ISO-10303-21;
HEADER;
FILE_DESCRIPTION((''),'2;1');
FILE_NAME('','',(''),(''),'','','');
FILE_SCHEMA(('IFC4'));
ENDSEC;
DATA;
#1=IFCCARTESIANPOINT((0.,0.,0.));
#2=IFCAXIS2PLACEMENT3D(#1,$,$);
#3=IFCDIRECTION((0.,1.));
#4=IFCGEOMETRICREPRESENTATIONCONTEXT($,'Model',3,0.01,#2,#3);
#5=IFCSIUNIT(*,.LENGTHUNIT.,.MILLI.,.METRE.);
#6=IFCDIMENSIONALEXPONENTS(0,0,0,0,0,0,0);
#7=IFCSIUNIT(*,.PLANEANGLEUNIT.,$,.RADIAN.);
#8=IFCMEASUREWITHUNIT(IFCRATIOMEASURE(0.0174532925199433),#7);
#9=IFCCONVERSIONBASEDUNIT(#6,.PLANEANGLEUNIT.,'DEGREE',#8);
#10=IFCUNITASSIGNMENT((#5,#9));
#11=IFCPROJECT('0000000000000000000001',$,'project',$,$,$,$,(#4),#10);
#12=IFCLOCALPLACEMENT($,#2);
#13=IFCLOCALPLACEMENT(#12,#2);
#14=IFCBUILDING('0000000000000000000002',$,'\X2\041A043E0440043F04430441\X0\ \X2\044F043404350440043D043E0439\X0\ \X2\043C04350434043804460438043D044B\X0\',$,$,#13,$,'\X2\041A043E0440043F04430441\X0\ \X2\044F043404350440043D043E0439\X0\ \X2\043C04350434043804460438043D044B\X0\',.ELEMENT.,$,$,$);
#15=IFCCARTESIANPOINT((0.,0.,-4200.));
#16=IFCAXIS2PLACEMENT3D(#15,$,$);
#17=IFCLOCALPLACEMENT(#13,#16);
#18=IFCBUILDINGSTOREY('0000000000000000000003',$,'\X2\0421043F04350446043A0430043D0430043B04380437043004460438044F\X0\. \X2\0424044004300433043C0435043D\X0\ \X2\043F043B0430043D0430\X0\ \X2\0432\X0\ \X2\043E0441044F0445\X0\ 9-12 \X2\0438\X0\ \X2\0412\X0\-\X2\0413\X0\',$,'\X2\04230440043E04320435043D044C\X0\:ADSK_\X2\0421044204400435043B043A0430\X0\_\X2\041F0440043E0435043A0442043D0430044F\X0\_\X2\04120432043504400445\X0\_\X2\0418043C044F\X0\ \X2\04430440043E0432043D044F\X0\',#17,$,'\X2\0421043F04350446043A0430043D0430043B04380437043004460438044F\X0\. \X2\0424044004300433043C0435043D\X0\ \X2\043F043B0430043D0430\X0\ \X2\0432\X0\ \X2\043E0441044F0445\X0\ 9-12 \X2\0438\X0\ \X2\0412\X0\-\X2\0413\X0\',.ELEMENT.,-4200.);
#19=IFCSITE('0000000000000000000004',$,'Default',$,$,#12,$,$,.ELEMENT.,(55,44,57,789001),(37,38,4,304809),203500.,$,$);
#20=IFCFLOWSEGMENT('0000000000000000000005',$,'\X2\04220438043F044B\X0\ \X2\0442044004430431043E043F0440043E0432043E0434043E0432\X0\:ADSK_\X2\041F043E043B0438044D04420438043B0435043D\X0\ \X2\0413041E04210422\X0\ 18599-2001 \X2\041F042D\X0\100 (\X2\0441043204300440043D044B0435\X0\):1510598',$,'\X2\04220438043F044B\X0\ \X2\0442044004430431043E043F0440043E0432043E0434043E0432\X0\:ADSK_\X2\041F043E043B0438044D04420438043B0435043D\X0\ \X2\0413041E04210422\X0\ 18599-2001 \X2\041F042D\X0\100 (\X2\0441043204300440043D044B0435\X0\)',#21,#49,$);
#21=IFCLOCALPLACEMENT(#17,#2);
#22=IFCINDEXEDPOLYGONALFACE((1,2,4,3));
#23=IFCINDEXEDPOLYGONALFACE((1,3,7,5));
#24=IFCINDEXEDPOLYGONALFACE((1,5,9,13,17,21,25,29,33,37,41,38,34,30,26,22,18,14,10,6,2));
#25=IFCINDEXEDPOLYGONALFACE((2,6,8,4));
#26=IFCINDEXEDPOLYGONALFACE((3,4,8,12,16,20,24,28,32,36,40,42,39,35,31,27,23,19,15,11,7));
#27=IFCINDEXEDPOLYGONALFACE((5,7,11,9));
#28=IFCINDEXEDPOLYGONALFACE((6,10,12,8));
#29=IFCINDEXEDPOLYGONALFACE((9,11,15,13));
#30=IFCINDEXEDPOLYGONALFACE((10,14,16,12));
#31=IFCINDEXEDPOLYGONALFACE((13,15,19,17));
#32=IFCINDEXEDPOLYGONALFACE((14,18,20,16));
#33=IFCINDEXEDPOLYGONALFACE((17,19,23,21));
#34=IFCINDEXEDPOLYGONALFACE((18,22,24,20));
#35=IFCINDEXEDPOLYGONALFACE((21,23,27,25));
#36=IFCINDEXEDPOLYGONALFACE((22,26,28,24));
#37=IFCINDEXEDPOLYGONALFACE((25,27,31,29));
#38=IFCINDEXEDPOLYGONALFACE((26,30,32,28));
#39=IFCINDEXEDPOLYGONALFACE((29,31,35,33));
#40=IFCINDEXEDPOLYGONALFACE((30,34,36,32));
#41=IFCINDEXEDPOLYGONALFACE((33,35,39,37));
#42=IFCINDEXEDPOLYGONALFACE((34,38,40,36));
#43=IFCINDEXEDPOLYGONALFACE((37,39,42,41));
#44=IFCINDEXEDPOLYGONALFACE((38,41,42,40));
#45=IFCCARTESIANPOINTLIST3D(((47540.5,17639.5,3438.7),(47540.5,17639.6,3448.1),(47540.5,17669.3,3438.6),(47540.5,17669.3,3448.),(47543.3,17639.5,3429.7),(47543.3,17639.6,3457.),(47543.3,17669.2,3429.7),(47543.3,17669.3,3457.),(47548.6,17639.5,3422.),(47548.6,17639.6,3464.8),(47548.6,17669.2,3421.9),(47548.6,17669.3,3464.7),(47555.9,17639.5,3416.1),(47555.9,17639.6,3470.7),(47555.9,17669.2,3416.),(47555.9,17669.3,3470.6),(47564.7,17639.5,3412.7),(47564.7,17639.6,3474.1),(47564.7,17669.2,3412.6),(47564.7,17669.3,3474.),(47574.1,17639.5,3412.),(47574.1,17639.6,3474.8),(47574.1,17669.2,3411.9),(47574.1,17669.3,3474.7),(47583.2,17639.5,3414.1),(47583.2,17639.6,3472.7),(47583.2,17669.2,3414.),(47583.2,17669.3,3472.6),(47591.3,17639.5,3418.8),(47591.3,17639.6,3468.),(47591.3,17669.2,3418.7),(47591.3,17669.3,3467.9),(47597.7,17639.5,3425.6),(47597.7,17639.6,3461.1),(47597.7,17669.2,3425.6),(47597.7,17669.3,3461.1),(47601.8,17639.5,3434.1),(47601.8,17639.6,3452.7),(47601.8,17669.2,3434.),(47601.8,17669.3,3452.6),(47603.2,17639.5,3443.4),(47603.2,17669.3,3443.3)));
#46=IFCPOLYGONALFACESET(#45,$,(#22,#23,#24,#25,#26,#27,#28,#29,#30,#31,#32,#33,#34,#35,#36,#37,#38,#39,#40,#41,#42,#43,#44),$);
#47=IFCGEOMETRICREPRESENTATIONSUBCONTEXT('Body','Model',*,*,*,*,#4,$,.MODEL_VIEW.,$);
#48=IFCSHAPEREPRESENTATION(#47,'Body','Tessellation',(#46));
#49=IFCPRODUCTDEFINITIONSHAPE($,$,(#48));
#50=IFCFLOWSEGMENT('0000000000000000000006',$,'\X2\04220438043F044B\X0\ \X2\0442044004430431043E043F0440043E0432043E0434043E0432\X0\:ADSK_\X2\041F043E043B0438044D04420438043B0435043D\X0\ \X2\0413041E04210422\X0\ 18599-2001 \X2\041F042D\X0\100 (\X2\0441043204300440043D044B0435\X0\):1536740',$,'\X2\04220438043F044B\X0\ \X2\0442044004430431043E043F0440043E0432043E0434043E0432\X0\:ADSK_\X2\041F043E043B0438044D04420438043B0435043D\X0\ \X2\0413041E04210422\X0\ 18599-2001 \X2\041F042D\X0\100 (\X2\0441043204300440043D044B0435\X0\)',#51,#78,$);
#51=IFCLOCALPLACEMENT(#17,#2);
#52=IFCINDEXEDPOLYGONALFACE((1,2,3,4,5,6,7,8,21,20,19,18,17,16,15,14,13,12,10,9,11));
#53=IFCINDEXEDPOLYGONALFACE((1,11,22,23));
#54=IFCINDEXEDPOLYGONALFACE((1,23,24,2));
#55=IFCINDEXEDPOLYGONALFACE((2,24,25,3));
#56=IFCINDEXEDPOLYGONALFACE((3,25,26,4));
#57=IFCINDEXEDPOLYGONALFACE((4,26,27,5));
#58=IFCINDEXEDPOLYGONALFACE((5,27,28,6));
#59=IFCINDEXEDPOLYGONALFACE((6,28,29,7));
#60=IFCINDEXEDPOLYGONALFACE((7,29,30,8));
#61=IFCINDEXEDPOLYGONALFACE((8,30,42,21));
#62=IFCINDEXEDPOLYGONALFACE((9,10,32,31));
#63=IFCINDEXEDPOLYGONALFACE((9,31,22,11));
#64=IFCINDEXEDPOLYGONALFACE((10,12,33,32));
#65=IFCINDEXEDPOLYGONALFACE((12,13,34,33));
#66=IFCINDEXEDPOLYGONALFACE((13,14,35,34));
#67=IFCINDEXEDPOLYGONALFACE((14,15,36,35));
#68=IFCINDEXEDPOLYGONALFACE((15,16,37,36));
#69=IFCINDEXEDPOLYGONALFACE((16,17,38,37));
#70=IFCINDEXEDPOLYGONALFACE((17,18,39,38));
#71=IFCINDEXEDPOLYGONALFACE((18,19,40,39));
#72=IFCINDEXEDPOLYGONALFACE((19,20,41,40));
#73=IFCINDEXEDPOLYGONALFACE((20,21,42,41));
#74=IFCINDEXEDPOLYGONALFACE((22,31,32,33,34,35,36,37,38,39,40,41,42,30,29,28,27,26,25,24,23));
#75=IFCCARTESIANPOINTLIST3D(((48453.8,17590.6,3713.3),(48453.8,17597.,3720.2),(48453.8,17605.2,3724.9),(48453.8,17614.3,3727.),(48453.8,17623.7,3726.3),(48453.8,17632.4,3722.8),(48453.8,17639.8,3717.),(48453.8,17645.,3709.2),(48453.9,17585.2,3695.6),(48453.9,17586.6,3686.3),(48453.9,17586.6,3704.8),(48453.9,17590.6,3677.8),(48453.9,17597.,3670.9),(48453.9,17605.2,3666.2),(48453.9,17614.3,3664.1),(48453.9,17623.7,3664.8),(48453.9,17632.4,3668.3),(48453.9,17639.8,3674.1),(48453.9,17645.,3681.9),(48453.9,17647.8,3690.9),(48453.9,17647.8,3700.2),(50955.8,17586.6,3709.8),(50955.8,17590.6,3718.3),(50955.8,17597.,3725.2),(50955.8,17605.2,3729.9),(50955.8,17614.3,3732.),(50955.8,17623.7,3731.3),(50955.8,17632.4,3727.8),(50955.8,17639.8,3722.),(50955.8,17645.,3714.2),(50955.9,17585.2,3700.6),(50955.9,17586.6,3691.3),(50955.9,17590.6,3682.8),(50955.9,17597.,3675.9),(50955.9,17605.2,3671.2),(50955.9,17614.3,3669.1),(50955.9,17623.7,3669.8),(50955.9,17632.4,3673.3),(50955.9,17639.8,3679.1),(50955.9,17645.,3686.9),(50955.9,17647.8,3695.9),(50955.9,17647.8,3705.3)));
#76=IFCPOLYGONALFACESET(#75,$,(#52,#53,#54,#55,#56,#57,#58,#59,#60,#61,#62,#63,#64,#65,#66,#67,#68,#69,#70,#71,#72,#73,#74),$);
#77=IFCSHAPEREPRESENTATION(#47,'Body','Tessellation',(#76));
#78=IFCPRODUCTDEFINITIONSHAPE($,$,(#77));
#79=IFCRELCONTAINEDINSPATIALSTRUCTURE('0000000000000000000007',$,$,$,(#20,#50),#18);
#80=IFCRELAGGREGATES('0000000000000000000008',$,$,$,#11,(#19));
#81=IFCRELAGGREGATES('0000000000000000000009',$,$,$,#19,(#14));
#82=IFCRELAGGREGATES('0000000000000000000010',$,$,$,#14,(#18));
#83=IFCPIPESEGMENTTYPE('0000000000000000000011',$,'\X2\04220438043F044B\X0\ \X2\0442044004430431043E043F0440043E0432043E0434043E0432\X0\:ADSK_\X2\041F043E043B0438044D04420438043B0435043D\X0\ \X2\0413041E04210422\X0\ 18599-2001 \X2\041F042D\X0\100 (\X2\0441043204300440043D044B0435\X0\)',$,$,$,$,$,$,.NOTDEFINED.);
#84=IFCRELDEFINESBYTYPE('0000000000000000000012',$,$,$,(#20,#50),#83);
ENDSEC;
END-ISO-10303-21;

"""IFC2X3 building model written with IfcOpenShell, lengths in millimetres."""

from ifc_helpers import new_model, entity, si_unit, converted_unit, direction, frame, frame_2d, origin, origin_2d_with_axis, place, context, subcontext, project, spatial, circle, extrude, type_object, element, save


model = new_model("IFC2X3")

# Units and contexts
model_context = context("Model", 3, precision=0.01, world=origin(), true_north=direction((0.0, 1.0)))
body_context = subcontext(model_context, "Body", "Model", "MODEL_VIEW")
ifc_project = project(units=[si_unit("LENGTHUNIT", "METRE", prefix="MILLI"), converted_unit("PLANEANGLEUNIT", "DEGREE", entity("IfcRatioMeasure", 0.0174532925199433), si_unit("PLANEANGLEUNIT", "RADIAN"), dimensions=[0, 0, 0, 0, 0, 0, 0])], contexts=[model_context])

# Site, building, storey
site_placement = place(None, frame((0.0, 0.0, 0.0)))
site = spatial("IfcSite", under=ifc_project, at=site_placement, Name="Default", CompositionType="ELEMENT", RefLatitude=(55, 44, 57, 789001), RefLongitude=(37, 38, 4, 304809), RefElevation=203500.0)
building_placement = place(site_placement, origin())
building = spatial("IfcBuilding", under=site, at=building_placement, Name="Корпус ядерной медицины", LongName="Корпус ядерной медицины", CompositionType="ELEMENT")
storey_placement = place(building_placement, frame((0.0, 0.0, -4200.0)))
storey = spatial("IfcBuildingStorey", under=building, at=storey_placement, Name="Спецканализация. Фрагмен плана в осях 9-12 и В-Г", ObjectType="Уровень:ADSK_Стрелка_Проектная_Вверх_Имя уровня", LongName="Спецканализация. Фрагмен плана в осях 9-12 и В-Г", CompositionType="ELEMENT", Elevation=-4200.0)

# Flow segments
pipe_segment_type = type_object("IfcPipeSegmentType", Name="Типы трубопроводов:ADSK_Полиэтилен ГОСТ 18599-2001 ПЭ100 (сварные)", PredefinedType="NOTDEFINED")
flow_segment_1_placement = place(storey_placement, frame((47538.6, 17639.5, 3410.2)))
element("IfcFlowSegment", 1, at=flow_segment_1_placement, inside=storey, type_object=pipe_segment_type, Name="Типы трубопроводов:ADSK_Полиэтилен ГОСТ 18599-2001 ПЭ100 (сварные):1510598", ObjectType="Типы трубопроводов:ADSK_Полиэтилен ГОСТ 18599-2001 ПЭ100 (сварные)", context=body_context, shape_type="SweptSolid", body=[
    extrude(circle(Radius=31.5, at=origin_2d_with_axis()), frame((33.1, 29.8, 33.1), z_axis=(0.0, -0.999998, 0.002), x_axis=(1.0, 0.0, 0.0)), (0.0, 0.0, 1.0), 29.7),
])
flow_segment_2_placement = place(storey_placement, frame((48453.8, 17583.6, 3662.5)))
element("IfcFlowSegment", 2, at=flow_segment_2_placement, inside=storey, type_object=pipe_segment_type, Name="Типы трубопроводов:ADSK_Полиэтилен ГОСТ 18599-2001 ПЭ100 (сварные):1536740", ObjectType="Типы трубопроводов:ADSK_Полиэтилен ГОСТ 18599-2001 ПЭ100 (сварные)", context=body_context, shape_type="SweptSolid", body=[
    extrude(circle(Radius=31.5, at=frame_2d((0.0, 0.0), x_axis=(1.0, 0.0))), frame((0.1, 33.1, 33.1), z_axis=(0.999998, 0.0, 0.002), x_axis=(0.0, -1.0, 0.0)), (0.0, 0.0, 1.0), 2502.0),
])

save(model, "model.ifc")
